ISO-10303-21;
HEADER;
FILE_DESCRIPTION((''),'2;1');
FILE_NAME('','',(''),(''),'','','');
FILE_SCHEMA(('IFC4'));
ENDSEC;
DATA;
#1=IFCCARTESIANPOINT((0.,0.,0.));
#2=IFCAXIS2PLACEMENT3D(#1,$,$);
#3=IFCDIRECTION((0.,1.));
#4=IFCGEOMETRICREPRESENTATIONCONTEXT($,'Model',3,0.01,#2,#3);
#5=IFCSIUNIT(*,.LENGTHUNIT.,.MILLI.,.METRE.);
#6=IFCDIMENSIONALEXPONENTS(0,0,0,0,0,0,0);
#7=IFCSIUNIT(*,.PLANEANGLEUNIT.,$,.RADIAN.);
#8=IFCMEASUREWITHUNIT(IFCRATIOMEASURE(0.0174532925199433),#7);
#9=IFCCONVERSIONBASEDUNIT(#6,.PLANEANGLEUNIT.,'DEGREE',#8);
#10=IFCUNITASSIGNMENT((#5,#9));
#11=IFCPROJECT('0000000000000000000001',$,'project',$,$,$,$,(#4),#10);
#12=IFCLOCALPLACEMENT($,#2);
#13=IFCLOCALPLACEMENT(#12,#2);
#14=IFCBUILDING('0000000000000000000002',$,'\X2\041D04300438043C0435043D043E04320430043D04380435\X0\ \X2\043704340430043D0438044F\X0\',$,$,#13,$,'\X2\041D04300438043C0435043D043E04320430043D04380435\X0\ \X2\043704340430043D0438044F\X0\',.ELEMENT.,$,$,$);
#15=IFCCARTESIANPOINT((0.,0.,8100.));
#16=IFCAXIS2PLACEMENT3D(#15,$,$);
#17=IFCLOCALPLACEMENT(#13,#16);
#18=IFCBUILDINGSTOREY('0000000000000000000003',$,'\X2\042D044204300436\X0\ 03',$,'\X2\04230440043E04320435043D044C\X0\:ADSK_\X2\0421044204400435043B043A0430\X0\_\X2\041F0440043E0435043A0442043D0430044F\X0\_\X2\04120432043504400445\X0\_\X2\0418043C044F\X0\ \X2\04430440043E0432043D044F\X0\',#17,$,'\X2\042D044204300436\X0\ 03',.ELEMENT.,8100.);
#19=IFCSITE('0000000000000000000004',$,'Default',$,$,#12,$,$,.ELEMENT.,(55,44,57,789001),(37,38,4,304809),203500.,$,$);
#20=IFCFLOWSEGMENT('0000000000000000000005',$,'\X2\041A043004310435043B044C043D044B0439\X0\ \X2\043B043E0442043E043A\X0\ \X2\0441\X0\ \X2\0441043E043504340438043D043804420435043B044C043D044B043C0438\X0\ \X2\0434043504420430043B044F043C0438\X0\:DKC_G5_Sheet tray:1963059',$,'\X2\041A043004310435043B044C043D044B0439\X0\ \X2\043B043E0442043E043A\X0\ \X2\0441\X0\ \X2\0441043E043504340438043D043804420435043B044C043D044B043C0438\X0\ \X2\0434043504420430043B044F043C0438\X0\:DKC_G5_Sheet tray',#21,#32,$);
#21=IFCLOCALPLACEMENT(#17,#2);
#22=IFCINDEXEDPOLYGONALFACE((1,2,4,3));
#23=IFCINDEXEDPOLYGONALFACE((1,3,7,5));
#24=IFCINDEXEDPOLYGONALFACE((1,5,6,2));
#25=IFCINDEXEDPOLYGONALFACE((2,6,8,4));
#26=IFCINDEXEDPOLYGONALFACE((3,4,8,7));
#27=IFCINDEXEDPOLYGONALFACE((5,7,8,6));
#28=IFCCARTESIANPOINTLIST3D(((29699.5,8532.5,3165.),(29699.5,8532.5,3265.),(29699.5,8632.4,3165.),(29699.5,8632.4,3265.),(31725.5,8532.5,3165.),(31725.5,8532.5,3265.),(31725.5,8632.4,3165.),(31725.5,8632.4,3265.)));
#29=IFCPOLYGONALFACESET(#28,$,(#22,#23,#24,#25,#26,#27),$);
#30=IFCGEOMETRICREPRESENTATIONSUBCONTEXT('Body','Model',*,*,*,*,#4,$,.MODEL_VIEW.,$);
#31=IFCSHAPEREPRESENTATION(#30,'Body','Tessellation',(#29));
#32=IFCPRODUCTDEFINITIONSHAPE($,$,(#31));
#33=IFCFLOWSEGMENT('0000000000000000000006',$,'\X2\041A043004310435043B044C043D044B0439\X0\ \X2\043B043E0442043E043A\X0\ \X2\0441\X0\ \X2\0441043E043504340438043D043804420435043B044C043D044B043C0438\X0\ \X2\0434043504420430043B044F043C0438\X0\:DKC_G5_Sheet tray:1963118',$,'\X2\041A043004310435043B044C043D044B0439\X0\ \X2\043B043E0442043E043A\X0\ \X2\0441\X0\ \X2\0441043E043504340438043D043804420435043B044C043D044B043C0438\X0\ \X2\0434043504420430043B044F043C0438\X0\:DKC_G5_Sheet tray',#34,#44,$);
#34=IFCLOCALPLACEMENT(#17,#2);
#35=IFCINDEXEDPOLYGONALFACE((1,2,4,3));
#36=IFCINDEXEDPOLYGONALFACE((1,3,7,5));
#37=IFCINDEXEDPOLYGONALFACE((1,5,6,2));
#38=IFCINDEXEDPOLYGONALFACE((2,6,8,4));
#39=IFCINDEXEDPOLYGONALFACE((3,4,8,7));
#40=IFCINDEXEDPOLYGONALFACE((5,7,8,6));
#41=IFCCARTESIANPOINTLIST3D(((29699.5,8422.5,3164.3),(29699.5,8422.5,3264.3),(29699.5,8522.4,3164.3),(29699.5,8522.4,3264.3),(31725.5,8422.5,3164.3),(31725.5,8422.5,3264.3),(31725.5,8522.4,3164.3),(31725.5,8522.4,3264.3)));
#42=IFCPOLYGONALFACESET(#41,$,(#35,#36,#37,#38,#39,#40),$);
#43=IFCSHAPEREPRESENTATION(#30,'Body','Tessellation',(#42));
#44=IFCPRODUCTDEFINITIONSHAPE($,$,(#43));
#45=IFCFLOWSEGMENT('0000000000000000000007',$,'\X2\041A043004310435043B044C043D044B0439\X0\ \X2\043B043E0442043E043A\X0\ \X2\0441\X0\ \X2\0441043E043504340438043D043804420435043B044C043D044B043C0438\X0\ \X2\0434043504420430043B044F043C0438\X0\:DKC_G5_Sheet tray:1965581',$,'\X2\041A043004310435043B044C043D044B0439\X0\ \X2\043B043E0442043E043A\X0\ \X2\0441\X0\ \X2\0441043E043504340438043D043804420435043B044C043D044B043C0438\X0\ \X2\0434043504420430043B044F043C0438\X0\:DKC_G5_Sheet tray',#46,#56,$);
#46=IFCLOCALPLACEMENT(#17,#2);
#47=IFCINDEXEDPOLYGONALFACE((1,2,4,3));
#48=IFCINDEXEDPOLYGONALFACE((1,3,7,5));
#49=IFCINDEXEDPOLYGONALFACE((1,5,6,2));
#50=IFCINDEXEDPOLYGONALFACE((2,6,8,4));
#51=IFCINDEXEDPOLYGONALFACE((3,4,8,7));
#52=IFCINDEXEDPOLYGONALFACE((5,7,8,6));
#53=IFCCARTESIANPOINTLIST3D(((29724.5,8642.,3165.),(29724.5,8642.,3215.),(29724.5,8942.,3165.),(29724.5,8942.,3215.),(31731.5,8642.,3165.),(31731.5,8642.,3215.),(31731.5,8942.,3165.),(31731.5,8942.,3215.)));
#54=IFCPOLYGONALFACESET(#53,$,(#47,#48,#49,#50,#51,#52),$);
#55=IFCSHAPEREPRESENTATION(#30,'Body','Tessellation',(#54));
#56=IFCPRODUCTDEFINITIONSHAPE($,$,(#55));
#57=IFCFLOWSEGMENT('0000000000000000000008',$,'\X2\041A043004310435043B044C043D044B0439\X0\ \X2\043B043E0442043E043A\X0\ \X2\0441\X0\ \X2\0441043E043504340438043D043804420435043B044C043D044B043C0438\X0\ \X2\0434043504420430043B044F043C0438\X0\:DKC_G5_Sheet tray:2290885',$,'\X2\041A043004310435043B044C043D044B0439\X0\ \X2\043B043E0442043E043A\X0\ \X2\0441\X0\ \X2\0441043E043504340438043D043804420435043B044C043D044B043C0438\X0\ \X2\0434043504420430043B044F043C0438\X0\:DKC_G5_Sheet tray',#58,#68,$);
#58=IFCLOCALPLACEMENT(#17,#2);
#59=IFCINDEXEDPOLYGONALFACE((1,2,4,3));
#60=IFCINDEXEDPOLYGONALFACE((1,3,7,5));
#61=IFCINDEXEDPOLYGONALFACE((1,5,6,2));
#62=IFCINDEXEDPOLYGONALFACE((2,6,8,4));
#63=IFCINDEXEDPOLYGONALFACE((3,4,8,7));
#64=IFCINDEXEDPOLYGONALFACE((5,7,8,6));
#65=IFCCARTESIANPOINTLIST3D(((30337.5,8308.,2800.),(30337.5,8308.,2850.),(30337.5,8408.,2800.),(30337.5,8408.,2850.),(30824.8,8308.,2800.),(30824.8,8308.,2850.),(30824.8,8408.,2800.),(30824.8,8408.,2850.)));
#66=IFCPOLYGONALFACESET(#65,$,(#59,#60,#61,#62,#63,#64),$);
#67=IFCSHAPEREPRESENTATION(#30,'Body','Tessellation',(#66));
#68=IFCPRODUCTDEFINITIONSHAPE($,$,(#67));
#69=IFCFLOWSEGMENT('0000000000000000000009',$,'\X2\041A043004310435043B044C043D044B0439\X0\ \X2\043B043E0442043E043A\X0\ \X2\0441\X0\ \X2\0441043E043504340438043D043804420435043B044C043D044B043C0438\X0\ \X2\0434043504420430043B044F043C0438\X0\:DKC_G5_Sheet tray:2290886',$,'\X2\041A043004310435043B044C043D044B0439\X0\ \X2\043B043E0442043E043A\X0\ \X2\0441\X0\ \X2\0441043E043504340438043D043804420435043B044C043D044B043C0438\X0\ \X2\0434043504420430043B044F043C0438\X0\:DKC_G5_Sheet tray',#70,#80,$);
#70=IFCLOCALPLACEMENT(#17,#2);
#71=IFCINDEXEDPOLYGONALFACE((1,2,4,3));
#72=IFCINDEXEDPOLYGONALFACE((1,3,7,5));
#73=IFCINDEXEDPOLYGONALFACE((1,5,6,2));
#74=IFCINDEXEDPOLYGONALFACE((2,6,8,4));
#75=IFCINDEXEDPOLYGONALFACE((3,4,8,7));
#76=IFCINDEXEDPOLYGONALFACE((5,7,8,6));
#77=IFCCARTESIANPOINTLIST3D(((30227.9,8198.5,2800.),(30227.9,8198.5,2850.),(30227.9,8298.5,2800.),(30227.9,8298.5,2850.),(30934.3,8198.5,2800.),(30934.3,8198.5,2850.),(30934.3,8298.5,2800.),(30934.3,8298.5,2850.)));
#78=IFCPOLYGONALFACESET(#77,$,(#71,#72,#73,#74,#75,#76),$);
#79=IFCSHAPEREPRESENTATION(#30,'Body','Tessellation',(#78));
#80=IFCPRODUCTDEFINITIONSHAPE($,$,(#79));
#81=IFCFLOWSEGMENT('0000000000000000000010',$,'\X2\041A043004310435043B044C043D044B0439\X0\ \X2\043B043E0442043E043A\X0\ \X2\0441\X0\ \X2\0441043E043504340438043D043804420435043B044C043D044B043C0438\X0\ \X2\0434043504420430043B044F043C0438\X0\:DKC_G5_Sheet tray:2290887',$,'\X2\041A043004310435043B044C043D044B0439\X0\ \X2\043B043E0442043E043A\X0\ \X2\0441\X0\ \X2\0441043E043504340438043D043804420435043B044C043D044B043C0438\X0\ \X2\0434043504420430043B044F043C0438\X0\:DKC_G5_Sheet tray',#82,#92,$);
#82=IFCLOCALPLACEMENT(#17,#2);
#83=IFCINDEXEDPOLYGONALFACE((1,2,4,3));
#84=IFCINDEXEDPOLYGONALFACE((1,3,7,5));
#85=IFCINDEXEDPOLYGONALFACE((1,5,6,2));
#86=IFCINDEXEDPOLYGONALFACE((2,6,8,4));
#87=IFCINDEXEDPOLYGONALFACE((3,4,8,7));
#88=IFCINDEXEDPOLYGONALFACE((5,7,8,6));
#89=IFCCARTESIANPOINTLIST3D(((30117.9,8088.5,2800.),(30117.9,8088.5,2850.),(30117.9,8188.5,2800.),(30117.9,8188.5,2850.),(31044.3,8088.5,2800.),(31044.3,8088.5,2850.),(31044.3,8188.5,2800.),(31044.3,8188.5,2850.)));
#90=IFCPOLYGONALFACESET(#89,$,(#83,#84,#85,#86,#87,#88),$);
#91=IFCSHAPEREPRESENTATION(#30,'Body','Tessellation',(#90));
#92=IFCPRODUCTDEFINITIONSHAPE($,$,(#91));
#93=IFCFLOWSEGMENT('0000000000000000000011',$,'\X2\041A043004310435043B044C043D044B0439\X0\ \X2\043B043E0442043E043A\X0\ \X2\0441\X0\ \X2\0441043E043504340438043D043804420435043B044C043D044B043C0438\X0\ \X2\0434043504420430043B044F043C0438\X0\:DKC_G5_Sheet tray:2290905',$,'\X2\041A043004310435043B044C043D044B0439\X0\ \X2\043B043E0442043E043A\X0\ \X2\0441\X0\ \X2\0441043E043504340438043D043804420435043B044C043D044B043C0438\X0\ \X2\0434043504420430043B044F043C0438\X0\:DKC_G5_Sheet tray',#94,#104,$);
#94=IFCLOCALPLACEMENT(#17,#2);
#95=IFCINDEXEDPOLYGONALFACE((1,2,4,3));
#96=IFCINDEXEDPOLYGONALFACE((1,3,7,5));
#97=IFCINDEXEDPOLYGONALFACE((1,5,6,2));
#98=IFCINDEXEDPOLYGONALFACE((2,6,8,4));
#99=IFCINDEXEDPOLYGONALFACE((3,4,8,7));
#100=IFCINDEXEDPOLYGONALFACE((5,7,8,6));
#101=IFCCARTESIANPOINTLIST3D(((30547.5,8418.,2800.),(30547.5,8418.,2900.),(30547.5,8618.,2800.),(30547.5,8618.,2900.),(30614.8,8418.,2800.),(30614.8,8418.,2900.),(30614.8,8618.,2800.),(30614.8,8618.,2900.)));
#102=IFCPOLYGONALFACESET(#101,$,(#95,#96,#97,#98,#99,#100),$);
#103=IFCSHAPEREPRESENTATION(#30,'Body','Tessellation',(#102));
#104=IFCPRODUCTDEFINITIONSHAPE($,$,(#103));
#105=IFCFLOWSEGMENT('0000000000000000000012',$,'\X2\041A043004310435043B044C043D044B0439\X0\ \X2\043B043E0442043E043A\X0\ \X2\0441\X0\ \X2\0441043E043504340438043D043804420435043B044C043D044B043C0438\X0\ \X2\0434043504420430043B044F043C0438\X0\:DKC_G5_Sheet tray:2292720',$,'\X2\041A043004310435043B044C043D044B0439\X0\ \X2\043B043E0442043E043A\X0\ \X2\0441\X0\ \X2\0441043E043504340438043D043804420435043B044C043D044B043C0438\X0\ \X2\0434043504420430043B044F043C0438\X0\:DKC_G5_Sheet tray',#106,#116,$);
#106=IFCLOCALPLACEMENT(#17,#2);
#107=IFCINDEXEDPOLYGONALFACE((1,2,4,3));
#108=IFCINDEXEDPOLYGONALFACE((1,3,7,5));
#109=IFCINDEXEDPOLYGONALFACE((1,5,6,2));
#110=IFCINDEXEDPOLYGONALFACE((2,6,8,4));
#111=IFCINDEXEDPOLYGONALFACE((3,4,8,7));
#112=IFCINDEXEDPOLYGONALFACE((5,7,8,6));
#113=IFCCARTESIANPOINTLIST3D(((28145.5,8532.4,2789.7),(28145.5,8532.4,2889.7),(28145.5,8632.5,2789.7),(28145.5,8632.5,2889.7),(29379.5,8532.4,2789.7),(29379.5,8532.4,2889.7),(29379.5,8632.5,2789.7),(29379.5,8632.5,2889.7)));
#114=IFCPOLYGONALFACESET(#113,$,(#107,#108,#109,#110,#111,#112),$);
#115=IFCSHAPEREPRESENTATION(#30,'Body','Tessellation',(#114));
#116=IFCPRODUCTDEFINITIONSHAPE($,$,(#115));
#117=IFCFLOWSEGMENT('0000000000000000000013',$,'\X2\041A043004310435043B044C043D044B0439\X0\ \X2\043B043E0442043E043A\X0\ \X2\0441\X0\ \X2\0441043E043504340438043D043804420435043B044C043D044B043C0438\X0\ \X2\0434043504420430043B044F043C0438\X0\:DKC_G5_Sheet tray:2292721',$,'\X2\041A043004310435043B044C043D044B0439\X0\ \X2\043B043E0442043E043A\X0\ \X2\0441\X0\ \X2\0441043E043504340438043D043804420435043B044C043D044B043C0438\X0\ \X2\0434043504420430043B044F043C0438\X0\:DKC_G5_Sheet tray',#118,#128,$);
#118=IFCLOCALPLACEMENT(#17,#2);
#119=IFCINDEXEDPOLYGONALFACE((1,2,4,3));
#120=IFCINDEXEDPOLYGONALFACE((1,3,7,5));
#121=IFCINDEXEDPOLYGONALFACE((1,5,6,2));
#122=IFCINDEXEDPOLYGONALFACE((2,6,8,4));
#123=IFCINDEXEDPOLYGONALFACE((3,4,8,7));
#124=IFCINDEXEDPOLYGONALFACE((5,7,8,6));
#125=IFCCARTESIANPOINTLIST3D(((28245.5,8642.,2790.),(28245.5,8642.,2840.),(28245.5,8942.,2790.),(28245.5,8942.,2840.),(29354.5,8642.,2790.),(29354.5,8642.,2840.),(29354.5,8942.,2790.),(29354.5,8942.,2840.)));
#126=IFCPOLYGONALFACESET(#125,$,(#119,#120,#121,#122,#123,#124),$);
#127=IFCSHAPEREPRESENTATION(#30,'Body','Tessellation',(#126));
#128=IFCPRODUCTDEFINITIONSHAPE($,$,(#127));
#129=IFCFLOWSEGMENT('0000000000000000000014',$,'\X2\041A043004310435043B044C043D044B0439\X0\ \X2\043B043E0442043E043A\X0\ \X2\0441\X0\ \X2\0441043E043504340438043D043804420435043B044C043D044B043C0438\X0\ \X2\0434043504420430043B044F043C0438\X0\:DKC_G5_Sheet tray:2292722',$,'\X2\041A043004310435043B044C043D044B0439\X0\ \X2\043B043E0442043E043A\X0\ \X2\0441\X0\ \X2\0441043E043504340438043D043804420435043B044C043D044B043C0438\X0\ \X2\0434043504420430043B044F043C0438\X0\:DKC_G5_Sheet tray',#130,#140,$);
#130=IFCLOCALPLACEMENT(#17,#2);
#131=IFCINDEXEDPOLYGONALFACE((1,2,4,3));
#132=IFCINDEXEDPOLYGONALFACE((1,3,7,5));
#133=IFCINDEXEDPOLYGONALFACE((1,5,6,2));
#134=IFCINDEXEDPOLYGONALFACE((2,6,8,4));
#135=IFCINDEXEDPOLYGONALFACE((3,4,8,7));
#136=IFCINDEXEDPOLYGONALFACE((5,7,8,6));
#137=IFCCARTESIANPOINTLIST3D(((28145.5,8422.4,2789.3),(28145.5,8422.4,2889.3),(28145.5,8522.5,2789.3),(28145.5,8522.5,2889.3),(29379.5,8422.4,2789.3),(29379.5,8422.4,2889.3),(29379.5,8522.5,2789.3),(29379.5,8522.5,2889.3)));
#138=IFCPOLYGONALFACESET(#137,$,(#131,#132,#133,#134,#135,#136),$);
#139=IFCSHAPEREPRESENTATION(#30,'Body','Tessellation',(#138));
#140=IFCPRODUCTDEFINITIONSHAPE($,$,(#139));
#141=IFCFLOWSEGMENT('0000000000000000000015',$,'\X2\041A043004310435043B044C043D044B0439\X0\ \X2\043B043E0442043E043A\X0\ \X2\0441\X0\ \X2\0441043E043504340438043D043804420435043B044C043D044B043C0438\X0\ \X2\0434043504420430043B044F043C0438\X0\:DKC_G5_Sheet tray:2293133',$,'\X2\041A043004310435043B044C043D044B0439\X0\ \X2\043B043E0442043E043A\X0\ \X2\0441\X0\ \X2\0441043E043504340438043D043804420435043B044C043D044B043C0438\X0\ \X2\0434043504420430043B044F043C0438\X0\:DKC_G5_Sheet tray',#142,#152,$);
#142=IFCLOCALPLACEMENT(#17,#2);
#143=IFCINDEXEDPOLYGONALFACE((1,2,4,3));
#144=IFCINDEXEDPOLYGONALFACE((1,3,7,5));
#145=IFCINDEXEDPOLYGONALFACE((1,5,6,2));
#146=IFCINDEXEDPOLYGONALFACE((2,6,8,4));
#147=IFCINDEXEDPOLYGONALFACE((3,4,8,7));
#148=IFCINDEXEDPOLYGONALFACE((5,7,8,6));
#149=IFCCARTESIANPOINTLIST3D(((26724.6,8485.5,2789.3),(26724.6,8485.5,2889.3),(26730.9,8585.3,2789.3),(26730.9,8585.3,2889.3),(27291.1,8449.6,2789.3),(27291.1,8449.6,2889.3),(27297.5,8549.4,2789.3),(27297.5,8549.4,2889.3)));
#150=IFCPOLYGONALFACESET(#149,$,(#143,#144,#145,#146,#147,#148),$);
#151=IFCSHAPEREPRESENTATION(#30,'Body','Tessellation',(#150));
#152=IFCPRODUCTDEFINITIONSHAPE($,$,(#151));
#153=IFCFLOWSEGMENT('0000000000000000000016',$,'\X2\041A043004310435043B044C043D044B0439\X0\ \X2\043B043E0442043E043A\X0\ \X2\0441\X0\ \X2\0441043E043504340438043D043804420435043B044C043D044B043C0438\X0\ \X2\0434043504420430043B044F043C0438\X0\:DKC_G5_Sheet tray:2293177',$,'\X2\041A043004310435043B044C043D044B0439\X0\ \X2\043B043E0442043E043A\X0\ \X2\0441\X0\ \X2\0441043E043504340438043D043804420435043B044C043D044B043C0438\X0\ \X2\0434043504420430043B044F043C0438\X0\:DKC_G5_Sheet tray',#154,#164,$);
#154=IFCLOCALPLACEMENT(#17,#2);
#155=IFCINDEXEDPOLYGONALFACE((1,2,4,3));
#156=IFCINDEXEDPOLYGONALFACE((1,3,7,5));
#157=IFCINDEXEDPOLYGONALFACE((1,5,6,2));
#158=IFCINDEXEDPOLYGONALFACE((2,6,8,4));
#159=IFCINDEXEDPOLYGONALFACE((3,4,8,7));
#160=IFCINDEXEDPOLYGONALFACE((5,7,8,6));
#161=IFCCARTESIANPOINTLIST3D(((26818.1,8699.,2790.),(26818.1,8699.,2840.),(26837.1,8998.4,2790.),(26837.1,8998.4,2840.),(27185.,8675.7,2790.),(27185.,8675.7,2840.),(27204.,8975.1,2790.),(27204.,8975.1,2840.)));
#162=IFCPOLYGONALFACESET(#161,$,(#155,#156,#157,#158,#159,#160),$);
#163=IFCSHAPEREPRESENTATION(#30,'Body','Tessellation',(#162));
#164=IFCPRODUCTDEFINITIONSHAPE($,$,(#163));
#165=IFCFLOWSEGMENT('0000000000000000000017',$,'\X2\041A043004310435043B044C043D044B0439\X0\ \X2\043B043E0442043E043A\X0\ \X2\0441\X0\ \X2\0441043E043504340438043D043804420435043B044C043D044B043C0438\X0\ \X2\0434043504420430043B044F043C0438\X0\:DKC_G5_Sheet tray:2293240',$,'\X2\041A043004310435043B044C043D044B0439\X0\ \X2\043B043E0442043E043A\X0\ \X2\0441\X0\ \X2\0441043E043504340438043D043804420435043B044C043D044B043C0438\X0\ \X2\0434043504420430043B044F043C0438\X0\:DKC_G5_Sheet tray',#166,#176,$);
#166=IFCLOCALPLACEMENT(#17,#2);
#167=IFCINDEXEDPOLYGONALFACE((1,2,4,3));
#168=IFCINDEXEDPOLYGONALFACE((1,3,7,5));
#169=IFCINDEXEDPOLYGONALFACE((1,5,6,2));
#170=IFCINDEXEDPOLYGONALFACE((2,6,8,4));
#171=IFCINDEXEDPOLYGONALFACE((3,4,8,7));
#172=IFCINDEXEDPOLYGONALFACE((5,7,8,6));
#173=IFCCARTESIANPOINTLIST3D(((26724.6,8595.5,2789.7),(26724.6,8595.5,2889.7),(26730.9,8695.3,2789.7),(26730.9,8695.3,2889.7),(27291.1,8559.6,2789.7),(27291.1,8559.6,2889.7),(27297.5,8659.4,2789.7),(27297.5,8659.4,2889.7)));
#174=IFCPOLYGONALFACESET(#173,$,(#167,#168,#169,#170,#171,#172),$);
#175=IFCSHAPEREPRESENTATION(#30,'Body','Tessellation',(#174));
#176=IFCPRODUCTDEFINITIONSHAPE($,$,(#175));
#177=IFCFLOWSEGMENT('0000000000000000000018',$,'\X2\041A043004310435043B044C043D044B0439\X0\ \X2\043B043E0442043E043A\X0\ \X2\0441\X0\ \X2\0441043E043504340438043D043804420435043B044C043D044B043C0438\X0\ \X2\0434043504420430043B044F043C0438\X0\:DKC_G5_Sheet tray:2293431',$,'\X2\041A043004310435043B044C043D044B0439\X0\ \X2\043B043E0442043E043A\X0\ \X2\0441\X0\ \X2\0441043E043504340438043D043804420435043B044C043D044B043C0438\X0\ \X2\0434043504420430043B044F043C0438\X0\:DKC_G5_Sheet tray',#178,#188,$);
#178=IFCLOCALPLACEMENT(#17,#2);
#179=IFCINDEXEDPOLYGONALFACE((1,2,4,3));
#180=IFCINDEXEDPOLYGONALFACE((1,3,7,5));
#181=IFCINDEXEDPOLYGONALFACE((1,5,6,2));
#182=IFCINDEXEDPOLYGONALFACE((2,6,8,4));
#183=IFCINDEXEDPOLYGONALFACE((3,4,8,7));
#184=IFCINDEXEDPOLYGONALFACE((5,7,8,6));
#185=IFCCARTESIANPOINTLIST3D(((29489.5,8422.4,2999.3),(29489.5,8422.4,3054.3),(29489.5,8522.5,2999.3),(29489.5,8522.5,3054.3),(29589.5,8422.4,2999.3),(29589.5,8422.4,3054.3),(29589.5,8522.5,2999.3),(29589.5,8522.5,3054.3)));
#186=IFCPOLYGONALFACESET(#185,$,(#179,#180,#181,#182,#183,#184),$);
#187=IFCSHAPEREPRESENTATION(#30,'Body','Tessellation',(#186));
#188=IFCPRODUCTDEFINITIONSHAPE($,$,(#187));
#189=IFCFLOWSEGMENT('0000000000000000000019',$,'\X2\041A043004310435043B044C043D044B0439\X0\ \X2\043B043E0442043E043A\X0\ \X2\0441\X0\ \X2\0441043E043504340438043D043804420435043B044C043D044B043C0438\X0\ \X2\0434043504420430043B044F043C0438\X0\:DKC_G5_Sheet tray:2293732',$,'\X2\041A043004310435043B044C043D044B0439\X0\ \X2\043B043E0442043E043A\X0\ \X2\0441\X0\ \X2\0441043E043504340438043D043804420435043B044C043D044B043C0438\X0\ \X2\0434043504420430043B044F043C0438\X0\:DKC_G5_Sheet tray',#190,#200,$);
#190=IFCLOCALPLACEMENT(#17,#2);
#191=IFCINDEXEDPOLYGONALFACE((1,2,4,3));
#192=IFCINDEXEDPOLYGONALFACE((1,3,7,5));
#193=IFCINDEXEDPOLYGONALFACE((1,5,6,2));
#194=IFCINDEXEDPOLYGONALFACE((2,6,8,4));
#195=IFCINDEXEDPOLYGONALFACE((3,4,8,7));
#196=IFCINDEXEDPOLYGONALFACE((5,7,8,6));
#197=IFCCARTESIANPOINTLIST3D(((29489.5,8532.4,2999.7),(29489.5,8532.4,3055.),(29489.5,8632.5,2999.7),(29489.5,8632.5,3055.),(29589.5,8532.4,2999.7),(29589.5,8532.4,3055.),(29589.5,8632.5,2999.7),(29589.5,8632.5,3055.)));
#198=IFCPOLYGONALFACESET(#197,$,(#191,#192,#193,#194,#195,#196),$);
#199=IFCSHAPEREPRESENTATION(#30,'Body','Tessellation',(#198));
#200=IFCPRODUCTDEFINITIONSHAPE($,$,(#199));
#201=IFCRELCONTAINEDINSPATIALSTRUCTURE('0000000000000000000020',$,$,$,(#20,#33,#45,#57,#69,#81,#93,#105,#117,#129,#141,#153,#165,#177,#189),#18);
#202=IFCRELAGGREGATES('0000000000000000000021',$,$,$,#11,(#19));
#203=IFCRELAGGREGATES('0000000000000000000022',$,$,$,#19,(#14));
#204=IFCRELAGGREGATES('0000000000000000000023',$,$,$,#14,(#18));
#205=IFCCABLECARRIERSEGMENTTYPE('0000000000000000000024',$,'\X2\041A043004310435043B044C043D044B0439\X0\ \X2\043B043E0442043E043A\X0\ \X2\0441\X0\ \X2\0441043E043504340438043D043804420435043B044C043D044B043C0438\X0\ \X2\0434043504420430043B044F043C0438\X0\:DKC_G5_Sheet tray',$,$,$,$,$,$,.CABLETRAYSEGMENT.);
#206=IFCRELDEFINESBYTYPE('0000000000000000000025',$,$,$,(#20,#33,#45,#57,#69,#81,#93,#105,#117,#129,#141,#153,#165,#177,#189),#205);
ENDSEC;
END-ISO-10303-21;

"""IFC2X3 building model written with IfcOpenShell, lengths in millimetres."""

from ifc_helpers import new_model, entity, si_unit, converted_unit, direction, frame, origin, origin_2d_with_axis, place, context, subcontext, project, spatial, rectangle, extrude, type_object, element, save


model = new_model("IFC2X3")

# Units and contexts
model_context = context("Model", 3, precision=0.01, world=origin(), true_north=direction((0.0, 1.0)))
body_context = subcontext(model_context, "Body", "Model", "MODEL_VIEW")
ifc_project = project(units=[si_unit("LENGTHUNIT", "METRE", prefix="MILLI"), converted_unit("PLANEANGLEUNIT", "DEGREE", entity("IfcRatioMeasure", 0.0174532925199433), si_unit("PLANEANGLEUNIT", "RADIAN"), dimensions=[0, 0, 0, 0, 0, 0, 0])], contexts=[model_context])

# Site, building, storey
site_placement = place(None, origin())
site = spatial("IfcSite", under=ifc_project, at=site_placement, Name="Default", CompositionType="ELEMENT", RefLatitude=(55, 44, 57, 789001), RefLongitude=(37, 38, 4, 304809), RefElevation=203500.0)
building_placement = place(site_placement, origin())
building = spatial("IfcBuilding", under=site, at=building_placement, Name="Наименование здания", LongName="Наименование здания", CompositionType="ELEMENT")
storey_placement = place(building_placement, frame((0.0, 0.0, 8100.0)))
storey = spatial("IfcBuildingStorey", under=building, at=storey_placement, Name="Этаж 03", ObjectType="Уровень:ADSK_Стрелка_Проектная_Вверх_Имя уровня", LongName="Этаж 03", CompositionType="ELEMENT", Elevation=8100.0)

# Flow segments
cable_carrier_segment_type = type_object("IfcCableCarrierSegmentType", Name="Кабельный лоток с соединительными деталями:DKC_G5_Sheet tray", PredefinedType="CABLETRAYSEGMENT")
flow_segment_1_placement = place(storey_placement, frame((29699.5, 8532.5, 3165.0)))
element("IfcFlowSegment", 1, at=flow_segment_1_placement, inside=storey, type_object=cable_carrier_segment_type, Name="Кабельный лоток с соединительными деталями:DKC_G5_Sheet tray:1963059", ObjectType="Кабельный лоток с соединительными деталями:DKC_G5_Sheet tray", context=body_context, shape_type="SweptSolid", body=[
    extrude(rectangle(XDim=2026.1, YDim=100.0, at=origin_2d_with_axis()), frame((1013.0, 50.0, 0.0)), (0.0, 0.0, 1.0), 100.0),
])
flow_segment_2_placement = place(storey_placement, frame((29699.5, 8422.5, 3164.3)))
element("IfcFlowSegment", 2, at=flow_segment_2_placement, inside=storey, type_object=cable_carrier_segment_type, Name="Кабельный лоток с соединительными деталями:DKC_G5_Sheet tray:1963118", ObjectType="Кабельный лоток с соединительными деталями:DKC_G5_Sheet tray", context=body_context, shape_type="SweptSolid", body=[
    extrude(rectangle(XDim=2026.1, YDim=100.0, at=origin_2d_with_axis()), frame((1013.0, 50.0, 0.0)), (0.0, 0.0, 1.0), 100.0),
])
flow_segment_3_placement = place(storey_placement, frame((29724.5, 8642.0, 3165.0)))
element("IfcFlowSegment", 3, at=flow_segment_3_placement, inside=storey, type_object=cable_carrier_segment_type, Name="Кабельный лоток с соединительными деталями:DKC_G5_Sheet tray:1965581", ObjectType="Кабельный лоток с соединительными деталями:DKC_G5_Sheet tray", context=body_context, shape_type="SweptSolid", body=[
    extrude(rectangle(XDim=2007.0, YDim=300.0, at=origin_2d_with_axis()), frame((1003.5, 150.0, 0.0)), (0.0, 0.0, 1.0), 50.0),
])
flow_segment_4_placement = place(storey_placement, frame((30337.5, 8308.0, 2800.0)))
element("IfcFlowSegment", 4, at=flow_segment_4_placement, inside=storey, type_object=cable_carrier_segment_type, Name="Кабельный лоток с соединительными деталями:DKC_G5_Sheet tray:2290885", ObjectType="Кабельный лоток с соединительными деталями:DKC_G5_Sheet tray", context=body_context, shape_type="SweptSolid", body=[
    extrude(rectangle(XDim=487.3, YDim=100.0, at=origin_2d_with_axis()), frame((243.7, 50.0, 0.0)), (0.0, 0.0, 1.0), 50.0),
])
flow_segment_5_placement = place(storey_placement, frame((30228.0, 8198.5, 2800.0)))
element("IfcFlowSegment", 5, at=flow_segment_5_placement, inside=storey, type_object=cable_carrier_segment_type, Name="Кабельный лоток с соединительными деталями:DKC_G5_Sheet tray:2290886", ObjectType="Кабельный лоток с соединительными деталями:DKC_G5_Sheet tray", context=body_context, shape_type="SweptSolid", body=[
    extrude(rectangle(XDim=706.4, YDim=100.0, at=origin_2d_with_axis()), frame((353.2, 50.0, 0.0)), (0.0, 0.0, 1.0), 50.0),
])
flow_segment_6_placement = place(storey_placement, frame((30118.0, 8088.5, 2800.0)))
element("IfcFlowSegment", 6, at=flow_segment_6_placement, inside=storey, type_object=cable_carrier_segment_type, Name="Кабельный лоток с соединительными деталями:DKC_G5_Sheet tray:2290887", ObjectType="Кабельный лоток с соединительными деталями:DKC_G5_Sheet tray", context=body_context, shape_type="SweptSolid", body=[
    extrude(rectangle(XDim=926.4, YDim=100.0, at=origin_2d_with_axis()), frame((463.2, 50.0, 0.0)), (0.0, 0.0, 1.0), 50.0),
])
flow_segment_7_placement = place(storey_placement, frame((30547.5, 8418.0, 2800.0)))
element("IfcFlowSegment", 7, at=flow_segment_7_placement, inside=storey, type_object=cable_carrier_segment_type, Name="Кабельный лоток с соединительными деталями:DKC_G5_Sheet tray:2290905", ObjectType="Кабельный лоток с соединительными деталями:DKC_G5_Sheet tray", context=body_context, shape_type="SweptSolid", body=[
    extrude(rectangle(XDim=67.3, YDim=200.0, at=origin_2d_with_axis()), frame((33.7, 100.0, 0.0)), (0.0, 0.0, 1.0), 100.0),
])
flow_segment_8_placement = place(storey_placement, frame((28145.5, 8532.5, 2789.7)))
element("IfcFlowSegment", 8, at=flow_segment_8_placement, inside=storey, type_object=cable_carrier_segment_type, Name="Кабельный лоток с соединительными деталями:DKC_G5_Sheet tray:2292720", ObjectType="Кабельный лоток с соединительными деталями:DKC_G5_Sheet tray", context=body_context, shape_type="SweptSolid", body=[
    extrude(rectangle(XDim=1234.0, YDim=100.0, at=origin_2d_with_axis()), frame((617.0, 50.0, 0.0), z_axis=(0.0, 0.0, 1.0), x_axis=(-1.0, 0.0, 0.0)), (0.0, 0.0, 1.0), 100.0),
])
flow_segment_9_placement = place(storey_placement, frame((28245.5, 8642.0, 2790.0)))
element("IfcFlowSegment", 9, at=flow_segment_9_placement, inside=storey, type_object=cable_carrier_segment_type, Name="Кабельный лоток с соединительными деталями:DKC_G5_Sheet tray:2292721", ObjectType="Кабельный лоток с соединительными деталями:DKC_G5_Sheet tray", context=body_context, shape_type="SweptSolid", body=[
    extrude(rectangle(XDim=1109.0, YDim=300.0, at=origin_2d_with_axis()), frame((554.5, 150.0, 0.0), z_axis=(0.0, 0.0, 1.0), x_axis=(-1.0, 0.0, 0.0)), (0.0, 0.0, 1.0), 50.0),
])
flow_segment_10_placement = place(storey_placement, frame((28145.5, 8422.5, 2789.3)))
element("IfcFlowSegment", 10, at=flow_segment_10_placement, inside=storey, type_object=cable_carrier_segment_type, Name="Кабельный лоток с соединительными деталями:DKC_G5_Sheet tray:2292722", ObjectType="Кабельный лоток с соединительными деталями:DKC_G5_Sheet tray", context=body_context, shape_type="SweptSolid", body=[
    extrude(rectangle(XDim=1234.0, YDim=100.0, at=origin_2d_with_axis()), frame((617.0, 50.0, 0.0), z_axis=(0.0, 0.0, 1.0), x_axis=(-1.0, 0.0, 0.0)), (0.0, 0.0, 1.0), 100.0),
])
flow_segment_11_placement = place(storey_placement, frame((26724.6, 8449.6, 2789.3)))
element("IfcFlowSegment", 11, at=flow_segment_11_placement, inside=storey, type_object=cable_carrier_segment_type, Name="Кабельный лоток с соединительными деталями:DKC_G5_Sheet tray:2293133", ObjectType="Кабельный лоток с соединительными деталями:DKC_G5_Sheet tray", context=body_context, shape_type="SweptSolid", body=[
    extrude(rectangle(XDim=567.7, YDim=100.0, at=origin_2d_with_axis()), frame((286.4, 67.9, 0.0), z_axis=(0.0, 0.0, 1.0), x_axis=(-0.997989, 0.063394, 0.0)), (0.0, 0.0, 1.0), 100.0),
])
flow_segment_12_placement = place(storey_placement, frame((26818.0, 8675.7, 2790.0)))
element("IfcFlowSegment", 12, at=flow_segment_12_placement, inside=storey, type_object=cable_carrier_segment_type, Name="Кабельный лоток с соединительными деталями:DKC_G5_Sheet tray:2293177", ObjectType="Кабельный лоток с соединительными деталями:DKC_G5_Sheet tray", context=body_context, shape_type="SweptSolid", body=[
    extrude(rectangle(XDim=367.7, YDim=300.0, at=origin_2d_with_axis()), frame((193.0, 161.3, 0.0), z_axis=(0.0, 0.0, 1.0), x_axis=(0.997989, -0.063394, 0.0)), (0.0, 0.0, 1.0), 50.0),
])
flow_segment_13_placement = place(storey_placement, frame((26724.6, 8559.6, 2789.7)))
element("IfcFlowSegment", 13, at=flow_segment_13_placement, inside=storey, type_object=cable_carrier_segment_type, Name="Кабельный лоток с соединительными деталями:DKC_G5_Sheet tray:2293240", ObjectType="Кабельный лоток с соединительными деталями:DKC_G5_Sheet tray", context=body_context, shape_type="SweptSolid", body=[
    extrude(rectangle(XDim=567.7, YDim=100.0, at=origin_2d_with_axis()), frame((286.4, 67.9, 0.0), z_axis=(0.0, 0.0, 1.0), x_axis=(-0.997989, 0.063394, 0.0)), (0.0, 0.0, 1.0), 100.0),
])
flow_segment_14_placement = place(storey_placement, frame((29489.5, 8422.5, 2999.3)))
element("IfcFlowSegment", 14, at=flow_segment_14_placement, inside=storey, type_object=cable_carrier_segment_type, Name="Кабельный лоток с соединительными деталями:DKC_G5_Sheet tray:2293431", ObjectType="Кабельный лоток с соединительными деталями:DKC_G5_Sheet tray", context=body_context, shape_type="SweptSolid", body=[
    extrude(rectangle(XDim=100.0, YDim=100.0, at=origin_2d_with_axis()), frame((50.0, 50.0, 0.0), z_axis=(0.0, 0.0, 1.0), x_axis=(0.0, 1.0, 0.0)), (0.0, 0.0, 1.0), 55.0),
])
flow_segment_15_placement = place(storey_placement, frame((29489.5, 8532.5, 2999.7)))
element("IfcFlowSegment", 15, at=flow_segment_15_placement, inside=storey, type_object=cable_carrier_segment_type, Name="Кабельный лоток с соединительными деталями:DKC_G5_Sheet tray:2293732", ObjectType="Кабельный лоток с соединительными деталями:DKC_G5_Sheet tray", context=body_context, shape_type="SweptSolid", body=[
    extrude(rectangle(XDim=100.0, YDim=100.0, at=origin_2d_with_axis()), frame((50.0, 50.0, 0.0), z_axis=(0.0, 0.0, 1.0), x_axis=(0.0, 1.0, 0.0)), (0.0, 0.0, 1.0), 55.3),
])

save(model, "model.ifc")
